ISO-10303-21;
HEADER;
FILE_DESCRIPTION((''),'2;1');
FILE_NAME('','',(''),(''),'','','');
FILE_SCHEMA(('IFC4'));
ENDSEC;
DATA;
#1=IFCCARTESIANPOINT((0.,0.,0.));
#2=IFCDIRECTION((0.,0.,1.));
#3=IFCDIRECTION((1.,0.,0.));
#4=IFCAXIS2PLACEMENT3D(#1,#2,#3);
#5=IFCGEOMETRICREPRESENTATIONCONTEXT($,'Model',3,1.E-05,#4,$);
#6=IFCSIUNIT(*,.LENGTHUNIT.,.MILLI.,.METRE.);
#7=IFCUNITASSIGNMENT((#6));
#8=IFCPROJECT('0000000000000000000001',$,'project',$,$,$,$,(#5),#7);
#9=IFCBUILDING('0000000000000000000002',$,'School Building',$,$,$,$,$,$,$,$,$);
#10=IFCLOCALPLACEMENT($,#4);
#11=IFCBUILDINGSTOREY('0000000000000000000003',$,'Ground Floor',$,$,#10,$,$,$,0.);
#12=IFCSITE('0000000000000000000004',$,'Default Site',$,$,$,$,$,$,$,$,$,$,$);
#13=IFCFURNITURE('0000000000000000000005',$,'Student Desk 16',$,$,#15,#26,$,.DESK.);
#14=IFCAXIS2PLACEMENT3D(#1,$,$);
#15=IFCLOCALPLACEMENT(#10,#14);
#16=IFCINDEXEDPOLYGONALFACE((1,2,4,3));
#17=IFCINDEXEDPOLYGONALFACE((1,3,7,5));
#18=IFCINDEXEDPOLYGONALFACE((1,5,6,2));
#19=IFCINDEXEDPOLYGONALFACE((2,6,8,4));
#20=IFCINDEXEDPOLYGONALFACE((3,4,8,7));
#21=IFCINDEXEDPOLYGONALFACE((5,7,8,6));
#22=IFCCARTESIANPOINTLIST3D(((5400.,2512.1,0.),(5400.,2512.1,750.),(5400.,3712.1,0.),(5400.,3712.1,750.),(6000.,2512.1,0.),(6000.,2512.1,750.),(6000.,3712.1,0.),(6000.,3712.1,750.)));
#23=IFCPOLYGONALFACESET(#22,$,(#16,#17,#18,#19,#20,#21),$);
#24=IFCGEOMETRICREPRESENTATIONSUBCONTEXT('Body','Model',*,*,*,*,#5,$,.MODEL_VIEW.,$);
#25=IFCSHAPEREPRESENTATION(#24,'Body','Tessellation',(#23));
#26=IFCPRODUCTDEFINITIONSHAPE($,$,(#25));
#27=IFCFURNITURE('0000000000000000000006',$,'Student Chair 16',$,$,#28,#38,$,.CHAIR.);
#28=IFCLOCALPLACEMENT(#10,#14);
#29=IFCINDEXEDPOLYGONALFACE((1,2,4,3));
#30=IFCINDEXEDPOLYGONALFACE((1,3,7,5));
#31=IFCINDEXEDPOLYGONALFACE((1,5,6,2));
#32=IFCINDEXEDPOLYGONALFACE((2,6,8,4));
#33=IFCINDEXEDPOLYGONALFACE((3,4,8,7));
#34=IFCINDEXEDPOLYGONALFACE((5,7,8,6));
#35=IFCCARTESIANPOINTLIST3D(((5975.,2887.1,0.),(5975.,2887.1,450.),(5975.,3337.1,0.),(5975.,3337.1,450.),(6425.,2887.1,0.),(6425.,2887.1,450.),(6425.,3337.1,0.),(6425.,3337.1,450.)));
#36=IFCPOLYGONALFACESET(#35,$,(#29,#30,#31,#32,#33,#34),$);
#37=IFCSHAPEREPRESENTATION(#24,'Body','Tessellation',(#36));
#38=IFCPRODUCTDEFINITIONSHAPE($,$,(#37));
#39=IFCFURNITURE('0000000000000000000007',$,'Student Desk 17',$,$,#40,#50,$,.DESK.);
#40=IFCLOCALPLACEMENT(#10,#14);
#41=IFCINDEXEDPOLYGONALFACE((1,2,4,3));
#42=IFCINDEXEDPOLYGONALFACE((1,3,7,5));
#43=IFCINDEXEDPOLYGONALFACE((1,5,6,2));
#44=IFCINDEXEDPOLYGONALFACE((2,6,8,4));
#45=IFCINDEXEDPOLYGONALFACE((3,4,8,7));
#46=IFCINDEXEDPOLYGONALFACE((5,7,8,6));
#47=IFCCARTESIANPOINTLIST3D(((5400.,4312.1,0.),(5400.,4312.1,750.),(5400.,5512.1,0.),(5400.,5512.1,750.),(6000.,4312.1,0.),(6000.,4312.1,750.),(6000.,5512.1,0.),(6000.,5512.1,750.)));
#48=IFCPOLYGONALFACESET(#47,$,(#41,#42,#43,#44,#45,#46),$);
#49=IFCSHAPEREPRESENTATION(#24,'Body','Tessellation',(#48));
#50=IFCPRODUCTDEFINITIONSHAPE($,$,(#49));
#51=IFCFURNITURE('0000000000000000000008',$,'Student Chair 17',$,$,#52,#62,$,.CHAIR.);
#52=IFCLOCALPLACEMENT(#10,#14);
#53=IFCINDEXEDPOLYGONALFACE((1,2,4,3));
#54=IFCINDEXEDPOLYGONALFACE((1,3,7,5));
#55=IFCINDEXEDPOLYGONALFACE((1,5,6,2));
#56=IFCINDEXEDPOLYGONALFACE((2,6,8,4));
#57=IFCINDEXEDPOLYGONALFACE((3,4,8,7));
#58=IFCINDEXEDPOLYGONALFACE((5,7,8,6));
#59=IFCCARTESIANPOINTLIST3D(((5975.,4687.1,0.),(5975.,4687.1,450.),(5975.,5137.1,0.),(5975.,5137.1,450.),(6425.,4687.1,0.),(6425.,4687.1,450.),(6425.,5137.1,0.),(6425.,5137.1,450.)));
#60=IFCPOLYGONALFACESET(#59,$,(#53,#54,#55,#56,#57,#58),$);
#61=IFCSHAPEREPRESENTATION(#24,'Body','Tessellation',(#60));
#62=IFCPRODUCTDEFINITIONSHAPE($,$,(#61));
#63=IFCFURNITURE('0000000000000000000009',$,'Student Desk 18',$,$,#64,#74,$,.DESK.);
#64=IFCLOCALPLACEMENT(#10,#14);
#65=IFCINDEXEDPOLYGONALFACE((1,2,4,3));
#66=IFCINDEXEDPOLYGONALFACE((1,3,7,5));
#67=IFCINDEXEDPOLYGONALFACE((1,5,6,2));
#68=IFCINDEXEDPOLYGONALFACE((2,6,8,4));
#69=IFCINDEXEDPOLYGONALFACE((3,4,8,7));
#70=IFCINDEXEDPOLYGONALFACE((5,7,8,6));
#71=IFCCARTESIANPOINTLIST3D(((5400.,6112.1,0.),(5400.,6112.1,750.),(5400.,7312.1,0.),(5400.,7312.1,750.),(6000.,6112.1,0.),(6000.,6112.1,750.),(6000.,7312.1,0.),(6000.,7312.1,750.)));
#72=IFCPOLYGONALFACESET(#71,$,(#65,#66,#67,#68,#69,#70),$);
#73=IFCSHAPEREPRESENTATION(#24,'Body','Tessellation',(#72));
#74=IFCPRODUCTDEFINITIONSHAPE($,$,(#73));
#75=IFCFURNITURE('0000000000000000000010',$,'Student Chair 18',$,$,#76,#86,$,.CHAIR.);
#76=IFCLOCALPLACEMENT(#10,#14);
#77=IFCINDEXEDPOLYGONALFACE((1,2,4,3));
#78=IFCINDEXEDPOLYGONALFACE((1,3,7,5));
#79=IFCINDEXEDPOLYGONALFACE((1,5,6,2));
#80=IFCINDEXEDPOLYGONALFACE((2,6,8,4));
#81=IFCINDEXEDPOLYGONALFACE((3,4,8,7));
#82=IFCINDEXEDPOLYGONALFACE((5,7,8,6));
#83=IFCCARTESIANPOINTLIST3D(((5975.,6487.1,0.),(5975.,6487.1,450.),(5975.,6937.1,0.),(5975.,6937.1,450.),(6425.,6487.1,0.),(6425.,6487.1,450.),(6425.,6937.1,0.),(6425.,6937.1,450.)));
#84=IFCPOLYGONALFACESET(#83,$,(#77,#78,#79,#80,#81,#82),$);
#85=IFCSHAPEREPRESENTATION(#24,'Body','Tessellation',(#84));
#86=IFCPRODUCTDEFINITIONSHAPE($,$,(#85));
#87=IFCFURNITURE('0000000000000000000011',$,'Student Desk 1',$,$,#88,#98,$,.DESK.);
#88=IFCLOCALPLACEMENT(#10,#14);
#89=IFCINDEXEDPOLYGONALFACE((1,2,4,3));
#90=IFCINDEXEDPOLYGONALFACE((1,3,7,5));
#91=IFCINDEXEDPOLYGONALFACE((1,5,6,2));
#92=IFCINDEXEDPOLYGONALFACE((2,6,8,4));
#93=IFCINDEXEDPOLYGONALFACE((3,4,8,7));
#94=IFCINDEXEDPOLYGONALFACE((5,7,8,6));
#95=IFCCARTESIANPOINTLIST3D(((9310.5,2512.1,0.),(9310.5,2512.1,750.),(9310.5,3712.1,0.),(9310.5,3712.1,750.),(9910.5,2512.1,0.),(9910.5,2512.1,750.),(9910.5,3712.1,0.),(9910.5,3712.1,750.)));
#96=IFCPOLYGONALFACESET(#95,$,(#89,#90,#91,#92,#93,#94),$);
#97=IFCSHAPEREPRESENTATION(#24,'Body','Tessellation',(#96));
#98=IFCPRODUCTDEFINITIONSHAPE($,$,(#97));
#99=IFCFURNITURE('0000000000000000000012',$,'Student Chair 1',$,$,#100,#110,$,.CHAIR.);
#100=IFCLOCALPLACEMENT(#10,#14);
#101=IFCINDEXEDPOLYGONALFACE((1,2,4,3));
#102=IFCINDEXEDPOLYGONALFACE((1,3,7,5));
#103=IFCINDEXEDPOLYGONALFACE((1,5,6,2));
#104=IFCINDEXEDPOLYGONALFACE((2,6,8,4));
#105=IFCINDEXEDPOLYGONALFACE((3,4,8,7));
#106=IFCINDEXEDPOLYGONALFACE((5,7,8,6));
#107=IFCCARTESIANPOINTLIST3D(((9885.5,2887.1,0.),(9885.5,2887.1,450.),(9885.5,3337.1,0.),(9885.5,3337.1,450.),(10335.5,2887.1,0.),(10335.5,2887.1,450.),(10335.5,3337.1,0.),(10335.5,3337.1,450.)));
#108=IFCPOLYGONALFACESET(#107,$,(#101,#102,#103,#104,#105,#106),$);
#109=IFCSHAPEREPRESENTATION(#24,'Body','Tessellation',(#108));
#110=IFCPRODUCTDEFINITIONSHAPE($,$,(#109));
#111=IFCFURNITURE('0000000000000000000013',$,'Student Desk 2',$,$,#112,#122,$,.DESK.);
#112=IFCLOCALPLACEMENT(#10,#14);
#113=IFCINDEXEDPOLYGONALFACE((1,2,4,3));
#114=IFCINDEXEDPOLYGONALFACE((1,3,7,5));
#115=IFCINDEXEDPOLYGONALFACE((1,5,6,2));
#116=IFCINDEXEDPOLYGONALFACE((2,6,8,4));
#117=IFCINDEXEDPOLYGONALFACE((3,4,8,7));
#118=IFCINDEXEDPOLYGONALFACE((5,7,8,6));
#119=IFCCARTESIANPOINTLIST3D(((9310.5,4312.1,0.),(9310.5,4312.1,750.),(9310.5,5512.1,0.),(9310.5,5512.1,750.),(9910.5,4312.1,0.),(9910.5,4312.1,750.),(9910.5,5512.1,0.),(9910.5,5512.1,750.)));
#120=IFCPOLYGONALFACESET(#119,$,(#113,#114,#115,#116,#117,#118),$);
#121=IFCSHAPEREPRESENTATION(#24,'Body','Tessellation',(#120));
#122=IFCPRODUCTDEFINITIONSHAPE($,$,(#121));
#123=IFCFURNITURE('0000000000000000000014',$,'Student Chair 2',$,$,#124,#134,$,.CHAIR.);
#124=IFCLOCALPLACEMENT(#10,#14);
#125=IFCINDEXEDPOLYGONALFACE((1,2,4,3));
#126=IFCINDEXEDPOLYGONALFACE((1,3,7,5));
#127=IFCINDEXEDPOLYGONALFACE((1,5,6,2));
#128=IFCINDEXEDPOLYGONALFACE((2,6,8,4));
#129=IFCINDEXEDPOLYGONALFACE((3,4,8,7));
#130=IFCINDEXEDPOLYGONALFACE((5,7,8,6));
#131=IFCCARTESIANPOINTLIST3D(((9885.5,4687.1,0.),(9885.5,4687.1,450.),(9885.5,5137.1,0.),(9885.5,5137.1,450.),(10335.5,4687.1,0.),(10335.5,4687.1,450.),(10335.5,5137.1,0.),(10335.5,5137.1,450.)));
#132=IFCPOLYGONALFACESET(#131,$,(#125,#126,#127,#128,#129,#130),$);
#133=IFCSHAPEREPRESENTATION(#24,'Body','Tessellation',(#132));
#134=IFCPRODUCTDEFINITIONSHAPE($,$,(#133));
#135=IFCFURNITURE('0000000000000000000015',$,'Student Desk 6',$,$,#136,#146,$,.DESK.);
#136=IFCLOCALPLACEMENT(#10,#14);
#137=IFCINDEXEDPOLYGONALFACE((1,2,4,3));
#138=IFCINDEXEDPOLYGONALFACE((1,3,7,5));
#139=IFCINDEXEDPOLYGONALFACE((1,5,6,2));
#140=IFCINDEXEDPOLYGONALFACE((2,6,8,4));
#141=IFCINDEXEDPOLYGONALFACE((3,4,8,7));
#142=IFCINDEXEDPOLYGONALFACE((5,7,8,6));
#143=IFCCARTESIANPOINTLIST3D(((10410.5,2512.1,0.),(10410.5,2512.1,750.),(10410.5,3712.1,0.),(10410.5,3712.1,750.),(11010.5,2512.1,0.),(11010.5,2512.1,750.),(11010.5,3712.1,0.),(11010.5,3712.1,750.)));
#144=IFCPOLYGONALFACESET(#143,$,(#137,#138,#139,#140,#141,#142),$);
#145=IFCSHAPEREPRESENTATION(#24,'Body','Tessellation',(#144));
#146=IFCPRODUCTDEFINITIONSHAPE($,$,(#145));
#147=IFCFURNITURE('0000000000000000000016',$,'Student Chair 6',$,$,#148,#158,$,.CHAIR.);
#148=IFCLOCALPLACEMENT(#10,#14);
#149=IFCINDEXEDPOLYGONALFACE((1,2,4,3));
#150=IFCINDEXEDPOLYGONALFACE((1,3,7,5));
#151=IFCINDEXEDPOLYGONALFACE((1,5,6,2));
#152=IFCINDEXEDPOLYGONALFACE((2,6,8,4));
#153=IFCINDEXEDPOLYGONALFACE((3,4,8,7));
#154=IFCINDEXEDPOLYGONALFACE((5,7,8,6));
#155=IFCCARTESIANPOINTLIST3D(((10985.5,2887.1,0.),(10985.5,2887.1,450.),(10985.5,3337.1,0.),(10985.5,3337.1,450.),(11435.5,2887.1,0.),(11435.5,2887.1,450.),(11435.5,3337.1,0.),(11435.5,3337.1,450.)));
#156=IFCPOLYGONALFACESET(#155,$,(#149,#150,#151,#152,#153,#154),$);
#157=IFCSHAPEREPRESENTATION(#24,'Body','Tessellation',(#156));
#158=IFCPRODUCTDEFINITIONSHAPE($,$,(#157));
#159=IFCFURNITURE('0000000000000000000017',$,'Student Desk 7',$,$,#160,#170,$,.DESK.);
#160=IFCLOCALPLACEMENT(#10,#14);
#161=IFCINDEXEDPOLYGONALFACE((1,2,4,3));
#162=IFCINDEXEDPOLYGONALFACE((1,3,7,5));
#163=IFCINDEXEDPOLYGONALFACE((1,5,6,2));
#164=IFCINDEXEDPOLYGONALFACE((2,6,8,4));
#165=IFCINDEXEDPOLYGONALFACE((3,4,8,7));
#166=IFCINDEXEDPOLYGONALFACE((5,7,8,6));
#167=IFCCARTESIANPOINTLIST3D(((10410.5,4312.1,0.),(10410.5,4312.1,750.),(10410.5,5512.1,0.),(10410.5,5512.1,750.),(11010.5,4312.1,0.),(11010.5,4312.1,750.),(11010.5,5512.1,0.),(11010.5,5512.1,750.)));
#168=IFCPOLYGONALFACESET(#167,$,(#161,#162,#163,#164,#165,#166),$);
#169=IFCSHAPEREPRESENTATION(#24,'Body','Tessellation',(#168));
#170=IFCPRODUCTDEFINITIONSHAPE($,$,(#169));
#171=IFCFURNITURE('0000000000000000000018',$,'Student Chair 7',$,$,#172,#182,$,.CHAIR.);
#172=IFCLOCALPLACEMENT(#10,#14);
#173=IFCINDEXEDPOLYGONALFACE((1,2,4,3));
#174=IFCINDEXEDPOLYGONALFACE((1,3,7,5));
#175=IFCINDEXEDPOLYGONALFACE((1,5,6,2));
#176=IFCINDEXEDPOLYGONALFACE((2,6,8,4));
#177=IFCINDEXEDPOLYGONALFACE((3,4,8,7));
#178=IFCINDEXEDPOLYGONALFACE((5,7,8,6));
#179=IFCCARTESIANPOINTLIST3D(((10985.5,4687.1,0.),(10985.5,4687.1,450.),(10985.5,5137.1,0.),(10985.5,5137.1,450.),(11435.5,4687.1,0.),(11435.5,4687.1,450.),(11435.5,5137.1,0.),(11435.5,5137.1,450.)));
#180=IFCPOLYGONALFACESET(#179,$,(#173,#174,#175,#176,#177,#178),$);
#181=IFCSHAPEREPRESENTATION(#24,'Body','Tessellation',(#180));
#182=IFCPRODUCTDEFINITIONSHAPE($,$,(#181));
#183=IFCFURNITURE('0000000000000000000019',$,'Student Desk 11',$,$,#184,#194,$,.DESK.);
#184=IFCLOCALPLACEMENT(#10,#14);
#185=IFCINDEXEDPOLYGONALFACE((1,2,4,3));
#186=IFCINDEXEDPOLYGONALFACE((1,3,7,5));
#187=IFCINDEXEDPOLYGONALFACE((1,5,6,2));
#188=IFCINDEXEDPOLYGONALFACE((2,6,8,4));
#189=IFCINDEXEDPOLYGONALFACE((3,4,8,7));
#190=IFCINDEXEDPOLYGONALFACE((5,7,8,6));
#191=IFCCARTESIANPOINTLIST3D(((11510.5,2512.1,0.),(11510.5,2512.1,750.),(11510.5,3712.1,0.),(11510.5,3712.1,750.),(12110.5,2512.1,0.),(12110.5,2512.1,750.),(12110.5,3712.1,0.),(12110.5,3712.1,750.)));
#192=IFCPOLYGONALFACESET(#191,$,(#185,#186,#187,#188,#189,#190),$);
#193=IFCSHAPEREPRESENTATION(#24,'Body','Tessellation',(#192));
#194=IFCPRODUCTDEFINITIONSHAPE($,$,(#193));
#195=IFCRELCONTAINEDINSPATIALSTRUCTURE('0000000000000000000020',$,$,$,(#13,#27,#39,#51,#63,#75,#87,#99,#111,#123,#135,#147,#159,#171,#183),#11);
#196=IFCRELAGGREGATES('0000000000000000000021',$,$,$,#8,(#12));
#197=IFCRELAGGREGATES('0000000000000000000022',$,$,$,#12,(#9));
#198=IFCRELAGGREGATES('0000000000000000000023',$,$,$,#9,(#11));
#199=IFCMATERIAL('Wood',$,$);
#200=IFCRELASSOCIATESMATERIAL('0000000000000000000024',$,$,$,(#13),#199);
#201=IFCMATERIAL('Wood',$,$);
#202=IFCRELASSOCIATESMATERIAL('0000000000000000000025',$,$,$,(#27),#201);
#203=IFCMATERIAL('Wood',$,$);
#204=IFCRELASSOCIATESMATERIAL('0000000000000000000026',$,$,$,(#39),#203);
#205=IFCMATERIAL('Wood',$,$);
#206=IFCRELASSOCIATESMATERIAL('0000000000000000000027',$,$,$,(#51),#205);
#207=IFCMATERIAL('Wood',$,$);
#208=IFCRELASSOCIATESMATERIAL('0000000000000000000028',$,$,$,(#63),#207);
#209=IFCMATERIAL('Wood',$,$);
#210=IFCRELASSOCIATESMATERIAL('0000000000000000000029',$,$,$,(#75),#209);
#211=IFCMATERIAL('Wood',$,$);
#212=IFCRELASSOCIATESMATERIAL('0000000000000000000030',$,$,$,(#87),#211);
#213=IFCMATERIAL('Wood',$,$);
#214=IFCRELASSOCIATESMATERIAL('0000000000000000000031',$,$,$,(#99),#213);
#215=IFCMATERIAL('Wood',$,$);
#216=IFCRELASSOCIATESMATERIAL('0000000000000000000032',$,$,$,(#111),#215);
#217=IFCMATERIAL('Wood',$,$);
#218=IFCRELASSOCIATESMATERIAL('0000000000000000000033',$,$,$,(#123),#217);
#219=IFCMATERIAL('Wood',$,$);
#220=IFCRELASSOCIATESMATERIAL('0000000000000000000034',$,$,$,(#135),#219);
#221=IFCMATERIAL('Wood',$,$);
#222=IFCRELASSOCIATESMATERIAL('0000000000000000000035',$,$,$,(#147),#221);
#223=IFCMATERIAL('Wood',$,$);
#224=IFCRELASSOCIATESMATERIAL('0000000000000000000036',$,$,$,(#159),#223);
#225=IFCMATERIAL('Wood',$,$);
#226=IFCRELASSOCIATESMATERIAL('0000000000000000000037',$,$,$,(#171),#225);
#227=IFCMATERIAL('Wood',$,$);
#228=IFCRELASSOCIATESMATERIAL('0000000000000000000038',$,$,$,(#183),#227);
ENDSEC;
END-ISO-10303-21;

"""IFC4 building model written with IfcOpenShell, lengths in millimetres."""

from ifc_helpers import new_model, si_unit, frame, origin_with_axes, origin_2d, place, context, subcontext, project, spatial, rectangle, extrude, material, element, save


model = new_model("IFC4")

# Units and contexts
model_context = context("Model", 3, precision=1e-05, world=origin_with_axes())
body_context = subcontext(model_context, "Body", "Model", "MODEL_VIEW")
ifc_project = project(units=[si_unit("LENGTHUNIT", "METRE", prefix="MILLI")], contexts=[model_context])

# Site, building, storey
site = spatial("IfcSite", under=ifc_project, Name="Default Site")
building = spatial("IfcBuilding", under=site, Name="School Building")
storey_placement = place(None, origin_with_axes())
storey = spatial("IfcBuildingStorey", under=building, at=storey_placement, Name="Ground Floor", Elevation=0.0)

# Furniture
ifc_material_1 = material(Name="Wood")
furniture_1_placement = place(storey_placement, frame((5700.0, 3112.1, 0.0), z_axis=(0.0, 0.0, 1.0), x_axis=(0.0, 1.0, 0.0)))
element("IfcFurniture", 1, at=furniture_1_placement, inside=storey, material=ifc_material_1, Name="Student Desk 16", PredefinedType="DESK", context=body_context, shape_type="SweptSolid", body=[
    extrude(rectangle(XDim=1200.0, YDim=600.0, at=origin_2d()), origin_with_axes(), (0.0, 0.0, 1.0), 750.0),
])
ifc_material_2 = material(Name="Wood")
furniture_2_placement = place(storey_placement, frame((6200.0, 3112.1, 0.0), z_axis=(0.0, 0.0, 1.0), x_axis=(1.0, 0.0, 0.0)))
element("IfcFurniture", 2, at=furniture_2_placement, inside=storey, material=ifc_material_2, Name="Student Chair 16", PredefinedType="CHAIR", context=body_context, shape_type="SweptSolid", body=[
    extrude(rectangle(XDim=450.0, YDim=450.0, at=origin_2d()), origin_with_axes(), (0.0, 0.0, 1.0), 450.0),
])
ifc_material_3 = material(Name="Wood")
furniture_3_placement = place(storey_placement, frame((5700.0, 4912.1, 0.0), z_axis=(0.0, 0.0, 1.0), x_axis=(0.0, 1.0, 0.0)))
element("IfcFurniture", 3, at=furniture_3_placement, inside=storey, material=ifc_material_3, Name="Student Desk 17", PredefinedType="DESK", context=body_context, shape_type="SweptSolid", body=[
    extrude(rectangle(XDim=1200.0, YDim=600.0, at=origin_2d()), origin_with_axes(), (0.0, 0.0, 1.0), 750.0),
])
ifc_material_4 = material(Name="Wood")
furniture_4_placement = place(storey_placement, frame((6200.0, 4912.1, 0.0), z_axis=(0.0, 0.0, 1.0), x_axis=(1.0, 0.0, 0.0)))
element("IfcFurniture", 4, at=furniture_4_placement, inside=storey, material=ifc_material_4, Name="Student Chair 17", PredefinedType="CHAIR", context=body_context, shape_type="SweptSolid", body=[
    extrude(rectangle(XDim=450.0, YDim=450.0, at=origin_2d()), origin_with_axes(), (0.0, 0.0, 1.0), 450.0),
])
ifc_material_5 = material(Name="Wood")
furniture_5_placement = place(storey_placement, frame((5700.0, 6712.1, 0.0), z_axis=(0.0, 0.0, 1.0), x_axis=(0.0, 1.0, 0.0)))
element("IfcFurniture", 5, at=furniture_5_placement, inside=storey, material=ifc_material_5, Name="Student Desk 18", PredefinedType="DESK", context=body_context, shape_type="SweptSolid", body=[
    extrude(rectangle(XDim=1200.0, YDim=600.0, at=origin_2d()), origin_with_axes(), (0.0, 0.0, 1.0), 750.0),
])
ifc_material_6 = material(Name="Wood")
furniture_6_placement = place(storey_placement, frame((6200.0, 6712.1, 0.0), z_axis=(0.0, 0.0, 1.0), x_axis=(1.0, 0.0, 0.0)))
element("IfcFurniture", 6, at=furniture_6_placement, inside=storey, material=ifc_material_6, Name="Student Chair 18", PredefinedType="CHAIR", context=body_context, shape_type="SweptSolid", body=[
    extrude(rectangle(XDim=450.0, YDim=450.0, at=origin_2d()), origin_with_axes(), (0.0, 0.0, 1.0), 450.0),
])
ifc_material_7 = material(Name="Wood")
furniture_7_placement = place(storey_placement, frame((9610.5, 3112.1, 0.0), z_axis=(0.0, 0.0, 1.0), x_axis=(0.0, 1.0, 0.0)))
element("IfcFurniture", 7, at=furniture_7_placement, inside=storey, material=ifc_material_7, Name="Student Desk 1", PredefinedType="DESK", context=body_context, shape_type="SweptSolid", body=[
    extrude(rectangle(XDim=1200.0, YDim=600.0, at=origin_2d()), origin_with_axes(), (0.0, 0.0, 1.0), 750.0),
])
ifc_material_8 = material(Name="Wood")
furniture_8_placement = place(storey_placement, frame((10110.5, 3112.1, 0.0), z_axis=(0.0, 0.0, 1.0), x_axis=(1.0, 0.0, 0.0)))
element("IfcFurniture", 8, at=furniture_8_placement, inside=storey, material=ifc_material_8, Name="Student Chair 1", PredefinedType="CHAIR", context=body_context, shape_type="SweptSolid", body=[
    extrude(rectangle(XDim=450.0, YDim=450.0, at=origin_2d()), origin_with_axes(), (0.0, 0.0, 1.0), 450.0),
])
ifc_material_9 = material(Name="Wood")
furniture_9_placement = place(storey_placement, frame((9610.5, 4912.1, 0.0), z_axis=(0.0, 0.0, 1.0), x_axis=(0.0, 1.0, 0.0)))
element("IfcFurniture", 9, at=furniture_9_placement, inside=storey, material=ifc_material_9, Name="Student Desk 2", PredefinedType="DESK", context=body_context, shape_type="SweptSolid", body=[
    extrude(rectangle(XDim=1200.0, YDim=600.0, at=origin_2d()), origin_with_axes(), (0.0, 0.0, 1.0), 750.0),
])
ifc_material_10 = material(Name="Wood")
furniture_10_placement = place(storey_placement, frame((10110.5, 4912.1, 0.0), z_axis=(0.0, 0.0, 1.0), x_axis=(1.0, 0.0, 0.0)))
element("IfcFurniture", 10, at=furniture_10_placement, inside=storey, material=ifc_material_10, Name="Student Chair 2", PredefinedType="CHAIR", context=body_context, shape_type="SweptSolid", body=[
    extrude(rectangle(XDim=450.0, YDim=450.0, at=origin_2d()), origin_with_axes(), (0.0, 0.0, 1.0), 450.0),
])
ifc_material_11 = material(Name="Wood")
furniture_11_placement = place(storey_placement, frame((10710.5, 3112.1, 0.0), z_axis=(0.0, 0.0, 1.0), x_axis=(0.0, 1.0, 0.0)))
element("IfcFurniture", 11, at=furniture_11_placement, inside=storey, material=ifc_material_11, Name="Student Desk 6", PredefinedType="DESK", context=body_context, shape_type="SweptSolid", body=[
    extrude(rectangle(XDim=1200.0, YDim=600.0, at=origin_2d()), origin_with_axes(), (0.0, 0.0, 1.0), 750.0),
])
ifc_material_12 = material(Name="Wood")
furniture_12_placement = place(storey_placement, frame((11210.5, 3112.1, 0.0), z_axis=(0.0, 0.0, 1.0), x_axis=(1.0, 0.0, 0.0)))
element("IfcFurniture", 12, at=furniture_12_placement, inside=storey, material=ifc_material_12, Name="Student Chair 6", PredefinedType="CHAIR", context=body_context, shape_type="SweptSolid", body=[
    extrude(rectangle(XDim=450.0, YDim=450.0, at=origin_2d()), origin_with_axes(), (0.0, 0.0, 1.0), 450.0),
])
ifc_material_13 = material(Name="Wood")
furniture_13_placement = place(storey_placement, frame((10710.5, 4912.1, 0.0), z_axis=(0.0, 0.0, 1.0), x_axis=(0.0, 1.0, 0.0)))
element("IfcFurniture", 13, at=furniture_13_placement, inside=storey, material=ifc_material_13, Name="Student Desk 7", PredefinedType="DESK", context=body_context, shape_type="SweptSolid", body=[
    extrude(rectangle(XDim=1200.0, YDim=600.0, at=origin_2d()), origin_with_axes(), (0.0, 0.0, 1.0), 750.0),
])
ifc_material_14 = material(Name="Wood")
furniture_14_placement = place(storey_placement, frame((11210.5, 4912.1, 0.0), z_axis=(0.0, 0.0, 1.0), x_axis=(1.0, 0.0, 0.0)))
element("IfcFurniture", 14, at=furniture_14_placement, inside=storey, material=ifc_material_14, Name="Student Chair 7", PredefinedType="CHAIR", context=body_context, shape_type="SweptSolid", body=[
    extrude(rectangle(XDim=450.0, YDim=450.0, at=origin_2d()), origin_with_axes(), (0.0, 0.0, 1.0), 450.0),
])
ifc_material_15 = material(Name="Wood")
furniture_15_placement = place(storey_placement, frame((11810.5, 3112.1, 0.0), z_axis=(0.0, 0.0, 1.0), x_axis=(0.0, 1.0, 0.0)))
element("IfcFurniture", 15, at=furniture_15_placement, inside=storey, material=ifc_material_15, Name="Student Desk 11", PredefinedType="DESK", context=body_context, shape_type="SweptSolid", body=[
    extrude(rectangle(XDim=1200.0, YDim=600.0, at=origin_2d()), origin_with_axes(), (0.0, 0.0, 1.0), 750.0),
])

save(model, "model.ifc")
